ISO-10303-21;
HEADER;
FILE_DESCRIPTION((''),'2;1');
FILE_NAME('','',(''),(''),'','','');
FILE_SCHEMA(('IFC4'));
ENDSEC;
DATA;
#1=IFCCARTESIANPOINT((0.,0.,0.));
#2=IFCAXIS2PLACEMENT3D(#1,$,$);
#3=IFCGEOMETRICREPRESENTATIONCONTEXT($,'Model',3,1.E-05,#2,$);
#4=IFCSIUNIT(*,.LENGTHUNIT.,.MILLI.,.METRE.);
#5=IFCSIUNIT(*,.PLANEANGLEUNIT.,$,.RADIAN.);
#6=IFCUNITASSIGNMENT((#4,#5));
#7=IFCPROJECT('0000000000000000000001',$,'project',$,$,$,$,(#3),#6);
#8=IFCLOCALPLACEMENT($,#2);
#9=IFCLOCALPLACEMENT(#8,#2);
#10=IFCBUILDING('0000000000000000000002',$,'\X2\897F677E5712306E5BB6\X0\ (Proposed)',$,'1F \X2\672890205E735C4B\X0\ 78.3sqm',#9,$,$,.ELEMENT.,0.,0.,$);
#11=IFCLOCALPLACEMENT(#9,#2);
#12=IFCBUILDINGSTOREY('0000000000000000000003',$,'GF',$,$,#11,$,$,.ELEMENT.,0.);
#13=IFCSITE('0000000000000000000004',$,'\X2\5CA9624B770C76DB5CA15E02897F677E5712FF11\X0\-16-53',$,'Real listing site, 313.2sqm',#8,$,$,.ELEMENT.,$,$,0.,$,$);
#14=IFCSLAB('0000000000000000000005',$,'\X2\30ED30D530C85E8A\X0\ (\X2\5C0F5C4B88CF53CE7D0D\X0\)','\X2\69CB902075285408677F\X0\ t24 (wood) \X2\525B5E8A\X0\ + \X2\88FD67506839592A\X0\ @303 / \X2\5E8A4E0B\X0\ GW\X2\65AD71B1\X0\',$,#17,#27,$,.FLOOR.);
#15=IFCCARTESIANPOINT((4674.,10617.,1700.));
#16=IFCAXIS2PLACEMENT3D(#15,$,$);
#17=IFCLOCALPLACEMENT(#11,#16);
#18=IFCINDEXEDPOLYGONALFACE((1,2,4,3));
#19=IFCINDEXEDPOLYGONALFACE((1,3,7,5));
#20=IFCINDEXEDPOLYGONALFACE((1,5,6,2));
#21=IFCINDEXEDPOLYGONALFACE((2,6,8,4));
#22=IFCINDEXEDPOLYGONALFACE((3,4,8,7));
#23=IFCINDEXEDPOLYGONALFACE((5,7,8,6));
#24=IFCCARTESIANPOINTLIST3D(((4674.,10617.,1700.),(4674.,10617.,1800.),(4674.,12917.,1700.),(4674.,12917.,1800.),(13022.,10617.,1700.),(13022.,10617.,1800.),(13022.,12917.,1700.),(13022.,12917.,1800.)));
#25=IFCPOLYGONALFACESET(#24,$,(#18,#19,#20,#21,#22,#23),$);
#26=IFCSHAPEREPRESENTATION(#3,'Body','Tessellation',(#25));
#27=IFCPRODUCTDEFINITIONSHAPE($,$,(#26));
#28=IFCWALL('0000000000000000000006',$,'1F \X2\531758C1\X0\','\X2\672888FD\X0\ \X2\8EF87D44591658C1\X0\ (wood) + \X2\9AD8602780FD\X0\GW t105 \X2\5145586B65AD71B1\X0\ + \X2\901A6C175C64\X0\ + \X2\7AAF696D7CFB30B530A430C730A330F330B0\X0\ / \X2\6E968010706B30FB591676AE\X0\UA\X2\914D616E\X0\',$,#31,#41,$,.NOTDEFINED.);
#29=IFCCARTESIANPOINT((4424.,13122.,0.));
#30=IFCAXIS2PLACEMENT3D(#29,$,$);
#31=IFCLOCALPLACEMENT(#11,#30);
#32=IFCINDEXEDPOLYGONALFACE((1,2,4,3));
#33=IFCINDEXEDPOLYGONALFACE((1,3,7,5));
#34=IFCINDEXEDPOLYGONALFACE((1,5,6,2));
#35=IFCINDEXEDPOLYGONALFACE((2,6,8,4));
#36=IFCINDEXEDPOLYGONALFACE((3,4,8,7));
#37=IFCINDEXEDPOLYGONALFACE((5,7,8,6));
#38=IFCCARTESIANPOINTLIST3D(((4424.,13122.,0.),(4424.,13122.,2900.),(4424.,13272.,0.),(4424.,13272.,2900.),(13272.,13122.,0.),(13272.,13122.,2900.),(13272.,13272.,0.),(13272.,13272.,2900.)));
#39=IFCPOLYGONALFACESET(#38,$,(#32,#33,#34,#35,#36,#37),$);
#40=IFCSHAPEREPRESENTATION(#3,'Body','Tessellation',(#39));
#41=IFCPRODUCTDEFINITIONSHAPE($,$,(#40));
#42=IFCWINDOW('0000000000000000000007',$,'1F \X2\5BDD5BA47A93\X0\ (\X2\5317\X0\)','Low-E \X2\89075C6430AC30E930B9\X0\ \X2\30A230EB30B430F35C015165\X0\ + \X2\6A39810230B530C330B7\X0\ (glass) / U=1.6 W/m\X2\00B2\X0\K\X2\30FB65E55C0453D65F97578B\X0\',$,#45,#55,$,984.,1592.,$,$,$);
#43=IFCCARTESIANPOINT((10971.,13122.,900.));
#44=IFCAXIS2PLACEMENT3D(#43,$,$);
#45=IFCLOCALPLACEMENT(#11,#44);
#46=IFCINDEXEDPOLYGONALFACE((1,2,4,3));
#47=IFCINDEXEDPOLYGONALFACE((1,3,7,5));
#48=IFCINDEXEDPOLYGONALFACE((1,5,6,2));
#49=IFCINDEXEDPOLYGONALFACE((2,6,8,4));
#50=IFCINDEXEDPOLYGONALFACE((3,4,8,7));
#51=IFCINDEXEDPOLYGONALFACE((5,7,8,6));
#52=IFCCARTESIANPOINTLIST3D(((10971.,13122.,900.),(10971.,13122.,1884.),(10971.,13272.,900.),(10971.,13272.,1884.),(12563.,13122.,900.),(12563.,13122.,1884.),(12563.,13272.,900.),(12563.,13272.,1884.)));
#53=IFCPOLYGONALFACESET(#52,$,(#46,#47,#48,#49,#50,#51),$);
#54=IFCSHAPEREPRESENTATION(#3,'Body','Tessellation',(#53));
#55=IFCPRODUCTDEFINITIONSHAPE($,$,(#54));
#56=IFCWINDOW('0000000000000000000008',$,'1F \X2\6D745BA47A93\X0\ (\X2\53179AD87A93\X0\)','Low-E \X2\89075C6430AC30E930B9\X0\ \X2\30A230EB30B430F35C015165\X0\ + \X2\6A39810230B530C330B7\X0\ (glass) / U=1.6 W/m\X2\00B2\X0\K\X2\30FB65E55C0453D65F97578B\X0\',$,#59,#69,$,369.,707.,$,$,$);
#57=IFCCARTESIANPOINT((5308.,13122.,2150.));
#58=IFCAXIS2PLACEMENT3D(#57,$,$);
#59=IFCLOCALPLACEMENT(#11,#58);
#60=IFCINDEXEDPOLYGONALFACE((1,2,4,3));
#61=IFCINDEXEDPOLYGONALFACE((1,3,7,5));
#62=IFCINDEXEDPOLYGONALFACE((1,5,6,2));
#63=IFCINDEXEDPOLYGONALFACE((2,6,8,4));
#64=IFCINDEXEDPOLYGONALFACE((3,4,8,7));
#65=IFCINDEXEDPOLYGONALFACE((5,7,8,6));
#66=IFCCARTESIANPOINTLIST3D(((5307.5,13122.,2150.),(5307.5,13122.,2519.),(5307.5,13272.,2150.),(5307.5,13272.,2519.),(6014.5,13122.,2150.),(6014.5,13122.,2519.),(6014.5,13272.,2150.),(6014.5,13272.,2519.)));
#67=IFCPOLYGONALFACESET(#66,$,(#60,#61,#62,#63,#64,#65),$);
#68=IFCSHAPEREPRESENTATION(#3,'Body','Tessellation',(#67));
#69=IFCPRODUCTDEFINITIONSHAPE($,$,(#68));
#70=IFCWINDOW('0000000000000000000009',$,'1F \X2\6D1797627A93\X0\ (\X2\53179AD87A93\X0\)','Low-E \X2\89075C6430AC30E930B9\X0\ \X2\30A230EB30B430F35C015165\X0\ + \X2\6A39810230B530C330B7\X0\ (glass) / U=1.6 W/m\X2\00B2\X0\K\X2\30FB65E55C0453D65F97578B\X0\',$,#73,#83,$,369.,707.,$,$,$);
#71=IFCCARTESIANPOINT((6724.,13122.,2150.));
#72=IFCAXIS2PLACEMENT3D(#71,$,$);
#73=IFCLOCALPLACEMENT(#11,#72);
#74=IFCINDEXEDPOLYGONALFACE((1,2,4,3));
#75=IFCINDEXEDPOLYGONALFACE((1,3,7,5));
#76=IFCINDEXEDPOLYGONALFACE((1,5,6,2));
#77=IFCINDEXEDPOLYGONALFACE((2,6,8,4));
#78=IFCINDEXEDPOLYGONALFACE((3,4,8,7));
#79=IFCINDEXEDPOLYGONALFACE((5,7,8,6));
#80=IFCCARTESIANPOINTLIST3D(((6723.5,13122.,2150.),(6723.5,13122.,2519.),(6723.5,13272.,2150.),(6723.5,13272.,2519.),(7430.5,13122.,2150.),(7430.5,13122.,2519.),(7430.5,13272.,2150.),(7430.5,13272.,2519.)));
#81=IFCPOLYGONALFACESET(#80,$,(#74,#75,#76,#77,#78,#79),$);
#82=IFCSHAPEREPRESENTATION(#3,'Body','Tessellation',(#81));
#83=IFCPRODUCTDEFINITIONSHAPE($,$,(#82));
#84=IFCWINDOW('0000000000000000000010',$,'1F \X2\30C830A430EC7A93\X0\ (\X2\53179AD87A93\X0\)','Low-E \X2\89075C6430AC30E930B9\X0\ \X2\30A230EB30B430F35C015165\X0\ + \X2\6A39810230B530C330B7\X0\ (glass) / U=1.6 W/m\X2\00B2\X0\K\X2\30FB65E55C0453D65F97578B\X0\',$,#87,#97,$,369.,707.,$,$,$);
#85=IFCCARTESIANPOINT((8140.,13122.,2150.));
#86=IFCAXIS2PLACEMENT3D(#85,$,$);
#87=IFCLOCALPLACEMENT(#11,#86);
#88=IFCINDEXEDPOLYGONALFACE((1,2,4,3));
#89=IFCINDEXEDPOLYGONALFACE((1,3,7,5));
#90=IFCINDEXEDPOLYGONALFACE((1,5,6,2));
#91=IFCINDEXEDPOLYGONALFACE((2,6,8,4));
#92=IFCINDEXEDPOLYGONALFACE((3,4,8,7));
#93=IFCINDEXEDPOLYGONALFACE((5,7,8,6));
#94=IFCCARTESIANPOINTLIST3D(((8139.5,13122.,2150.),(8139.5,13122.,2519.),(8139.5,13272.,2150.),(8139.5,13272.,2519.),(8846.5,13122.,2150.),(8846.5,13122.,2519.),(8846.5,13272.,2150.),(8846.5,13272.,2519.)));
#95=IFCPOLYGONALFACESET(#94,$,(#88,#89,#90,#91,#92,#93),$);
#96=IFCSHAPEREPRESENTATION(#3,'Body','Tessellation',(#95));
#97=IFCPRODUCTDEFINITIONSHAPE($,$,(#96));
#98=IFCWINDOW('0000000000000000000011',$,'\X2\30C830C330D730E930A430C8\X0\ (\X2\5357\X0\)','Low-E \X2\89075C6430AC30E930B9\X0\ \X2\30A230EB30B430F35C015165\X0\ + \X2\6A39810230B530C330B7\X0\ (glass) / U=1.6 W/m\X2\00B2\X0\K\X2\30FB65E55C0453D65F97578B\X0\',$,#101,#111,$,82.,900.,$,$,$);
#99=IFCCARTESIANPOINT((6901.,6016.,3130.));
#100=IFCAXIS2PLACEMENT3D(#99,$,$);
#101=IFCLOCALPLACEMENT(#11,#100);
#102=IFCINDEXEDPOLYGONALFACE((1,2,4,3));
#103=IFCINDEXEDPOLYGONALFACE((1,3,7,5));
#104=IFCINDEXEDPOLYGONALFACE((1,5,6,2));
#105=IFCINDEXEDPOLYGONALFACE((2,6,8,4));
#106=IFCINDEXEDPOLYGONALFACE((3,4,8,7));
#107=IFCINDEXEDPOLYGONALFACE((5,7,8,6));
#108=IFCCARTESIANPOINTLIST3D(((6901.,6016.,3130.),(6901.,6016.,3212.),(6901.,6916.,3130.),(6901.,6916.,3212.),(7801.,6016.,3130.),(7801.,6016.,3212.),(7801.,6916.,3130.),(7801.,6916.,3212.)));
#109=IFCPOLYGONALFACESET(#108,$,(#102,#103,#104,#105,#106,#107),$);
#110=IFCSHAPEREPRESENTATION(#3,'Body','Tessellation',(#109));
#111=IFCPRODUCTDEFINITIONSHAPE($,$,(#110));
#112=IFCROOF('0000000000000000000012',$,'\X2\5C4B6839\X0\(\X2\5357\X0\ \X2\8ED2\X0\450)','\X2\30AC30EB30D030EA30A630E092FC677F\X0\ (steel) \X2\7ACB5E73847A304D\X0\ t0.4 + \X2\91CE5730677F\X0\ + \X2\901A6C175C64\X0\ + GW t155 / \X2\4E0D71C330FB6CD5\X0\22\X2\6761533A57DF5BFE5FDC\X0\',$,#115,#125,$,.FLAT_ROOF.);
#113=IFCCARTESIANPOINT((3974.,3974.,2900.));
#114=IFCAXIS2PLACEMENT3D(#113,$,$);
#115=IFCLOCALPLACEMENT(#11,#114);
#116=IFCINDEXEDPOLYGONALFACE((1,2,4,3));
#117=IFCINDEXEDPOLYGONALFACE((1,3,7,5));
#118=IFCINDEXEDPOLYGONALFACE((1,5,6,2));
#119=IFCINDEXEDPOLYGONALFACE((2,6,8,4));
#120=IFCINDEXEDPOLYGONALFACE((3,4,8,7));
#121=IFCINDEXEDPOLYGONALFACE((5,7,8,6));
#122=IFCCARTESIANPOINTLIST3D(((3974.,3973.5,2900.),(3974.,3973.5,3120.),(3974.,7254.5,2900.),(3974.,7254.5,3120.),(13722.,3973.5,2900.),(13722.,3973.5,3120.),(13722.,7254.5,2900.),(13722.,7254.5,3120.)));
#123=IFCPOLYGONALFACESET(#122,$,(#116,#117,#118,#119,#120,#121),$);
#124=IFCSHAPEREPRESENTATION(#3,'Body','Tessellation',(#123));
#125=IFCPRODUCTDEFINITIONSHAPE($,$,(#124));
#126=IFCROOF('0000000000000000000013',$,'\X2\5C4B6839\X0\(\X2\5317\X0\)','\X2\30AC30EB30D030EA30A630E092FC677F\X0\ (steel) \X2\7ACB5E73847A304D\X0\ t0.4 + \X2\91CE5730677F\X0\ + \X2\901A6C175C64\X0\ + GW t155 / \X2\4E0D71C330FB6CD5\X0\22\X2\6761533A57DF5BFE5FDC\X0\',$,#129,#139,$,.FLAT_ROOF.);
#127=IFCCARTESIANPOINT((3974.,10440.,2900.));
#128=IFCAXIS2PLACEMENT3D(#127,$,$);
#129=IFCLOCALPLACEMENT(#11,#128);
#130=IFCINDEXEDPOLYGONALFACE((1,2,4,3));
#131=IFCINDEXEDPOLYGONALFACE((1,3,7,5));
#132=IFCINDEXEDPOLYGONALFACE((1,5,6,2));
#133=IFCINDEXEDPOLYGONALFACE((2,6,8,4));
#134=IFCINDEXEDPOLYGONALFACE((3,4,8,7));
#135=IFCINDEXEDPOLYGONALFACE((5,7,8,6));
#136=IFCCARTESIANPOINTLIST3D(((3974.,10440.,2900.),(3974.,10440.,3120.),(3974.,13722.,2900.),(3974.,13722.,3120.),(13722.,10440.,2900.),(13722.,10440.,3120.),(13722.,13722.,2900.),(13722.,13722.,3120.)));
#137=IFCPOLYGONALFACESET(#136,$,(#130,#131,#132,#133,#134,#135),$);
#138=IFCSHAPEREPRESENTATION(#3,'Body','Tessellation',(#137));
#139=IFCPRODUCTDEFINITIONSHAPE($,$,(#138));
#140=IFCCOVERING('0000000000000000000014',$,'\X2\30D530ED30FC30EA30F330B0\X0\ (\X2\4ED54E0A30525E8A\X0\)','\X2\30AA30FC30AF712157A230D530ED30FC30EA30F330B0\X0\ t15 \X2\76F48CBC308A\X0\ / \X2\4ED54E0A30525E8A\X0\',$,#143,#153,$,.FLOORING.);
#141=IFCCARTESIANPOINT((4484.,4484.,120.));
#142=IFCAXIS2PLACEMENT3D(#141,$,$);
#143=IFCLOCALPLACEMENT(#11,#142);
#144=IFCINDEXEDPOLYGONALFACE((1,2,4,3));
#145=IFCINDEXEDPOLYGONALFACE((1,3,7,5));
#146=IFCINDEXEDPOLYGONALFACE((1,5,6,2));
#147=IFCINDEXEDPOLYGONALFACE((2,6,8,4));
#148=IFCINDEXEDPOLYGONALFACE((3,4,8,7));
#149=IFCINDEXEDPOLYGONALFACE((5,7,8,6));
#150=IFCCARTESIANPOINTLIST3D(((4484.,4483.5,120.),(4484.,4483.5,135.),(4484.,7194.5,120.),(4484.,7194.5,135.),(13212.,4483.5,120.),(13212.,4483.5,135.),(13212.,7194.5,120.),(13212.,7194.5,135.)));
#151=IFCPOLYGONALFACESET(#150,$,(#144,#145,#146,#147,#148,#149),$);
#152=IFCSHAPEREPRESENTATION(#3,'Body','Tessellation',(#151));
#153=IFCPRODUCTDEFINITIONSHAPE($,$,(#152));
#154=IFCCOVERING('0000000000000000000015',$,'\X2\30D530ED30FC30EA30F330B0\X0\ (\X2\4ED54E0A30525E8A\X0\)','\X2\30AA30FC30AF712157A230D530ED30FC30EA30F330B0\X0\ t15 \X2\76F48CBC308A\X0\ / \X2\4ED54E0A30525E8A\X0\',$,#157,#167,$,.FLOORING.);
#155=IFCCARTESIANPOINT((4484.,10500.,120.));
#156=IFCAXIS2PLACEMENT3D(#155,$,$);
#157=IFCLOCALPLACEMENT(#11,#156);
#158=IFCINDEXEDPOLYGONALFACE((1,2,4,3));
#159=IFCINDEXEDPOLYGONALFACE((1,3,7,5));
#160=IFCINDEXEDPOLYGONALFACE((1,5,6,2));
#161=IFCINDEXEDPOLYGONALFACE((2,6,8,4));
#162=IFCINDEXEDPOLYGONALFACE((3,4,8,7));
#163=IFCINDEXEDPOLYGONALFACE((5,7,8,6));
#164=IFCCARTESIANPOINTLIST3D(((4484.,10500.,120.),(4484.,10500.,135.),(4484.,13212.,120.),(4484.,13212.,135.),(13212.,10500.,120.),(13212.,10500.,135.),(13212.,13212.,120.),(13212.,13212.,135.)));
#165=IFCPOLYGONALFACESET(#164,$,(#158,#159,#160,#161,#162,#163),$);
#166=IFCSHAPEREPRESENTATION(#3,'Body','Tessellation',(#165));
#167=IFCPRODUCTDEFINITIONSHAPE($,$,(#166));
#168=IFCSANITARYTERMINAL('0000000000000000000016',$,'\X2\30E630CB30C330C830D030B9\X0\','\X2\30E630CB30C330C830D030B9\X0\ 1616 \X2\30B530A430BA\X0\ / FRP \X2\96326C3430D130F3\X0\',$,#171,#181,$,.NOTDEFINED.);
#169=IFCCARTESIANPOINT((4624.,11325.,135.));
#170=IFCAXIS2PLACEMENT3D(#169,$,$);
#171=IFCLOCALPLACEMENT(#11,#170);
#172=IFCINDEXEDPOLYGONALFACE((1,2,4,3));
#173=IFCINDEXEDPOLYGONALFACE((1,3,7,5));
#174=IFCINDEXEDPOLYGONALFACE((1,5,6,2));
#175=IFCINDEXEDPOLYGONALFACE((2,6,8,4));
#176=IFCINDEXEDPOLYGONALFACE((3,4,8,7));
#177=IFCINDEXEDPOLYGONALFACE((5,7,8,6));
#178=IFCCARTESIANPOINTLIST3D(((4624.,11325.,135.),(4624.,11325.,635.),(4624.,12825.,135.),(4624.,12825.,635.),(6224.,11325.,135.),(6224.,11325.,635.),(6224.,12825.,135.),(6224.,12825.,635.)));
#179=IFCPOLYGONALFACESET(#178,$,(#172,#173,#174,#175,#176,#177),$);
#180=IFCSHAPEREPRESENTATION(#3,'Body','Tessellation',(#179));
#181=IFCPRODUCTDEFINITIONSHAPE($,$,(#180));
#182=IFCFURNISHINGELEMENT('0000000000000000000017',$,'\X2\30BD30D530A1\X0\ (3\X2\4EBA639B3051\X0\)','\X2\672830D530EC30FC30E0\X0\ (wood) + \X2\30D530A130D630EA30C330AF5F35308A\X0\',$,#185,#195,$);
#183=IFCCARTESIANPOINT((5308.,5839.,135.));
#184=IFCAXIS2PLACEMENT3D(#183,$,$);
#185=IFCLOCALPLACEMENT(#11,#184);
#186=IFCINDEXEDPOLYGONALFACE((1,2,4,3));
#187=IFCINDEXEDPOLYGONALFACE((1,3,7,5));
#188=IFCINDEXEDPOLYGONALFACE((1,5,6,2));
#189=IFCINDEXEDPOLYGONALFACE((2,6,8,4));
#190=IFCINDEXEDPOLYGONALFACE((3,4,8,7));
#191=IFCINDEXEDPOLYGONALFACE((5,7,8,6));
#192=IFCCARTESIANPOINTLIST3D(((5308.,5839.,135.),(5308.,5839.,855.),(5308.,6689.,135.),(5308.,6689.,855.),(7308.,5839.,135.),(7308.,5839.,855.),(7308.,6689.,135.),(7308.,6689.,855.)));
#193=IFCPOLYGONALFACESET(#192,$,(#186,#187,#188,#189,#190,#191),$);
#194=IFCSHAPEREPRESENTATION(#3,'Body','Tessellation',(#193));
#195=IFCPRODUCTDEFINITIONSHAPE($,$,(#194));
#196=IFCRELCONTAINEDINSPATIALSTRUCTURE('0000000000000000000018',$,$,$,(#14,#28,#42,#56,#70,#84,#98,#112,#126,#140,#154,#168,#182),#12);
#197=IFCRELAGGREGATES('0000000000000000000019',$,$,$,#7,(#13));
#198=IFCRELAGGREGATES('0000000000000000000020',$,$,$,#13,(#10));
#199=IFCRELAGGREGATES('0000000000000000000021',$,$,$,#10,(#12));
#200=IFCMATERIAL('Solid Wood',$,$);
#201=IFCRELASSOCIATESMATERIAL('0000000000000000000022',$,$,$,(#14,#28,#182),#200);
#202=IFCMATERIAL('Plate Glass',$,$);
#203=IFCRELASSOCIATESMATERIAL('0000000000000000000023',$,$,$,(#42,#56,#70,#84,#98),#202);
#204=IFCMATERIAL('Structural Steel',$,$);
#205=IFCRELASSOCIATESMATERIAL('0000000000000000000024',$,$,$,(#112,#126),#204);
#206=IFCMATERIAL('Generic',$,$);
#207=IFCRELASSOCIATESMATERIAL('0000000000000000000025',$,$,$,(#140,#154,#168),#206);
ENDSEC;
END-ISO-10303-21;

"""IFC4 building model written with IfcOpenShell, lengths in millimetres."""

from ifc_helpers import new_model, si_unit, frame, frame_2d, origin, place, context, project, spatial, rectangle, extrude, material, element, fill, save


model = new_model("IFC4")

# Units and contexts
model_context = context("Model", 3, precision=1e-05, world=origin())
ifc_project = project(units=[si_unit("LENGTHUNIT", "METRE", prefix="MILLI"), si_unit("PLANEANGLEUNIT", "RADIAN")], contexts=[model_context])

# Site, building, storey
site_placement = place(None, origin())
site = spatial("IfcSite", under=ifc_project, at=site_placement, Name="岩手県盛岡市西松園１-16-53", ObjectType="Real listing site, 313.2sqm", CompositionType="ELEMENT", RefElevation=0.0)
building_placement = place(site_placement, origin())
building = spatial("IfcBuilding", under=site, at=building_placement, Name="西松園の家 (Proposed)", ObjectType="1F 木造平屋 78.3sqm", CompositionType="ELEMENT", ElevationOfRefHeight=0.0, ElevationOfTerrain=0.0)
storey_placement = place(building_placement, origin())
storey = spatial("IfcBuildingStorey", under=building, at=storey_placement, Name="GF", CompositionType="ELEMENT", Elevation=0.0)

# Slab
ifc_material_1 = material(Name="Solid Wood")
slab_1_placement = place(storey_placement, frame((4674.0, 10617.0, 1700.0)))
element("IfcSlab", 1, at=slab_1_placement, inside=storey, material=ifc_material_1, Name="ロフト床 (小屋裏収納)", Description="構造用合板 t24 (wood) 剛床 + 製材根太 @303 / 床下 GW断熱", PredefinedType="FLOOR", context=model_context, shape_type="SweptSolid", body=[
    extrude(rectangle(XDim=8348.0, YDim=2300.0, at=frame_2d((4174.0, 1150.0))), frame((4674.0, 10617.0, 1700.0)), (0.0, 0.0, 1.0), 100.0),
])

# Shared definitions
ifc_material_2 = material(Name="Plate Glass")

# Wall, openings, windows
wall_1_placement = place(storey_placement, frame((4424.0, 13122.0, 0.0)))
wall_1 = element("IfcWall", 2, at=wall_1_placement, inside=storey, material=ifc_material_1, Name="1F 北壁", Description="木製 軸組外壁 (wood) + 高性能GW t105 充填断熱 + 通気層 + 窯業系サイディング / 準耐火・外皮UA配慮", PredefinedType="NOTDEFINED", context=model_context, shape_type="SweptSolid", body=[
    extrude(rectangle(XDim=8848.0, YDim=150.0, at=frame_2d((4424.0, 75.0))), frame((4424.0, 13122.0, 0.0)), (0.0, 0.0, 1.0), 2900.0),
])
opening_1_placement = place(storey_placement, frame((10971.0, 13122.0, 900.0)))
opening_1 = element("IfcOpeningElement", 3, at=opening_1_placement, cuts=wall_1, PredefinedType="NOTDEFINED", context=model_context, shape_type="SweptSolid", body=[
    extrude(rectangle(XDim=1592.0, YDim=150.0, at=frame_2d((796.0, 75.0))), frame((10971.0, 13122.0, 900.0)), (0.0, 0.0, 1.0), 984.0),
])
opening_2_placement = place(storey_placement, frame((5308.0, 13122.0, 2150.0)))
opening_2 = element("IfcOpeningElement", 4, at=opening_2_placement, cuts=wall_1, PredefinedType="NOTDEFINED", context=model_context, shape_type="SweptSolid", body=[
    extrude(rectangle(XDim=707.0, YDim=150.0, at=frame_2d((353.0, 75.0))), frame((5308.0, 13122.0, 2150.0)), (0.0, 0.0, 1.0), 369.0),
])
opening_3_placement = place(storey_placement, frame((6724.0, 13122.0, 2150.0)))
opening_3 = element("IfcOpeningElement", 5, at=opening_3_placement, cuts=wall_1, PredefinedType="NOTDEFINED", context=model_context, shape_type="SweptSolid", body=[
    extrude(rectangle(XDim=707.0, YDim=150.0, at=frame_2d((353.0, 75.0))), frame((6724.0, 13122.0, 2150.0)), (0.0, 0.0, 1.0), 369.0),
])
opening_4_placement = place(storey_placement, frame((8140.0, 13122.0, 2150.0)))
opening_4 = element("IfcOpeningElement", 6, at=opening_4_placement, cuts=wall_1, PredefinedType="NOTDEFINED", context=model_context, shape_type="SweptSolid", body=[
    extrude(rectangle(XDim=707.0, YDim=150.0, at=frame_2d((353.0, 75.0))), frame((8140.0, 13122.0, 2150.0)), (0.0, 0.0, 1.0), 369.0),
])
window_1_placement = place(storey_placement, frame((10971.0, 13122.0, 900.0)))
window_1 = element("IfcWindow", 7, at=window_1_placement, inside=storey, material=ifc_material_2, Name="1F 寝室窓 (北)", Description="Low-E 複層ガラス アルゴン封入 + 樹脂サッシ (glass) / U=1.6 W/m²K・日射取得型", OverallHeight=984.0, OverallWidth=1592.0, context=model_context, shape_type="SweptSolid", body=[
    extrude(rectangle(XDim=1592.0, YDim=150.0, at=frame_2d((796.0, 75.0))), frame((10971.0, 13122.0, 900.0)), (0.0, 0.0, 1.0), 984.0),
])
fill(opening_1, window_1)
window_2_placement = place(storey_placement, frame((5308.0, 13122.0, 2150.0)))
window_2 = element("IfcWindow", 8, at=window_2_placement, inside=storey, material=ifc_material_2, Name="1F 浴室窓 (北高窓)", Description="Low-E 複層ガラス アルゴン封入 + 樹脂サッシ (glass) / U=1.6 W/m²K・日射取得型", OverallHeight=369.0, OverallWidth=707.0, context=model_context, shape_type="SweptSolid", body=[
    extrude(rectangle(XDim=707.0, YDim=150.0, at=frame_2d((353.0, 75.0))), frame((5308.0, 13122.0, 2150.0)), (0.0, 0.0, 1.0), 369.0),
])
fill(opening_2, window_2)
window_3_placement = place(storey_placement, frame((6724.0, 13122.0, 2150.0)))
window_3 = element("IfcWindow", 9, at=window_3_placement, inside=storey, material=ifc_material_2, Name="1F 洗面窓 (北高窓)", Description="Low-E 複層ガラス アルゴン封入 + 樹脂サッシ (glass) / U=1.6 W/m²K・日射取得型", OverallHeight=369.0, OverallWidth=707.0, context=model_context, shape_type="SweptSolid", body=[
    extrude(rectangle(XDim=707.0, YDim=150.0, at=frame_2d((353.0, 75.0))), frame((6724.0, 13122.0, 2150.0)), (0.0, 0.0, 1.0), 369.0),
])
fill(opening_3, window_3)
window_4_placement = place(storey_placement, frame((8140.0, 13122.0, 2150.0)))
window_4 = element("IfcWindow", 10, at=window_4_placement, inside=storey, material=ifc_material_2, Name="1F トイレ窓 (北高窓)", Description="Low-E 複層ガラス アルゴン封入 + 樹脂サッシ (glass) / U=1.6 W/m²K・日射取得型", OverallHeight=369.0, OverallWidth=707.0, context=model_context, shape_type="SweptSolid", body=[
    extrude(rectangle(XDim=707.0, YDim=150.0, at=frame_2d((353.0, 75.0))), frame((8140.0, 13122.0, 2150.0)), (0.0, 0.0, 1.0), 369.0),
])
fill(opening_4, window_4)

# Window
window_5_placement = place(storey_placement, frame((6901.0, 6016.0, 3130.0)))
element("IfcWindow", 11, at=window_5_placement, inside=storey, material=ifc_material_2, Name="トップライト (南)", Description="Low-E 複層ガラス アルゴン封入 + 樹脂サッシ (glass) / U=1.6 W/m²K・日射取得型", OverallHeight=82.0, OverallWidth=900.0, context=model_context, shape_type="SweptSolid", body=[
    extrude(rectangle(XDim=900.0, YDim=900.0, at=frame_2d((450.0, 450.0))), frame((6901.0, 6016.0, 3130.0)), (0.0, 0.0, 1.0), 82.0),
])

# Roofs
ifc_material_3 = material(Name="Structural Steel")
roof_1_placement = place(storey_placement, frame((3974.0, 3974.0, 2900.0)))
element("IfcRoof", 12, at=roof_1_placement, inside=storey, material=ifc_material_3, Name="屋根(南 軒450)", Description="ガルバリウム鋼板 (steel) 立平葺き t0.4 + 野地板 + 通気層 + GW t155 / 不燃・法22条区域対応", PredefinedType="FLAT_ROOF", context=model_context, shape_type="SweptSolid", body=[
    extrude(rectangle(XDim=9748.0, YDim=3281.0, at=frame_2d((4874.0, 1640.0))), frame((3974.0, 3974.0, 2900.0)), (0.0, 0.0, 1.0), 220.0),
])
roof_2_placement = place(storey_placement, frame((3974.0, 10440.0, 2900.0)))
element("IfcRoof", 13, at=roof_2_placement, inside=storey, material=ifc_material_3, Name="屋根(北)", Description="ガルバリウム鋼板 (steel) 立平葺き t0.4 + 野地板 + 通気層 + GW t155 / 不燃・法22条区域対応", PredefinedType="FLAT_ROOF", context=model_context, shape_type="SweptSolid", body=[
    extrude(rectangle(XDim=9748.0, YDim=3282.0, at=frame_2d((4874.0, 1641.0))), frame((3974.0, 10440.0, 2900.0)), (0.0, 0.0, 1.0), 220.0),
])

# Coverings
ifc_material_4 = material(Name="Generic")
covering_1_placement = place(storey_placement, frame((4484.0, 4484.0, 120.0)))
element("IfcCovering", 14, at=covering_1_placement, inside=storey, material=ifc_material_4, Name="フローリング (仕上げ床)", Description="オーク無垢フローリング t15 直貼り / 仕上げ床", PredefinedType="FLOORING", context=model_context, shape_type="SweptSolid", body=[
    extrude(rectangle(XDim=8728.0, YDim=2711.0, at=frame_2d((4364.0, 1355.0))), frame((4484.0, 4484.0, 120.0)), (0.0, 0.0, 1.0), 15.0),
])
covering_2_placement = place(storey_placement, frame((4484.0, 10500.0, 120.0)))
element("IfcCovering", 15, at=covering_2_placement, inside=storey, material=ifc_material_4, Name="フローリング (仕上げ床)", Description="オーク無垢フローリング t15 直貼り / 仕上げ床", PredefinedType="FLOORING", context=model_context, shape_type="SweptSolid", body=[
    extrude(rectangle(XDim=8728.0, YDim=2712.0, at=frame_2d((4364.0, 1356.0))), frame((4484.0, 10500.0, 120.0)), (0.0, 0.0, 1.0), 15.0),
])

# Sanitary terminal
sanitary_terminal_placement = place(storey_placement, frame((4624.0, 11325.0, 135.0)))
element("IfcSanitaryTerminal", 16, at=sanitary_terminal_placement, inside=storey, material=ifc_material_4, Name="ユニットバス", Description="ユニットバス 1616 サイズ / FRP 防水パン", PredefinedType="NOTDEFINED", context=model_context, shape_type="SweptSolid", body=[
    extrude(rectangle(XDim=1600.0, YDim=1500.0, at=frame_2d((800.0, 750.0))), frame((4624.0, 11325.0, 135.0)), (0.0, 0.0, 1.0), 500.0),
])

# Furnishing element
furnishing_1_placement = place(storey_placement, frame((5308.0, 5839.0, 135.0)))
element("IfcFurnishingElement", 17, at=furnishing_1_placement, inside=storey, material=ifc_material_1, Name="ソファ (3人掛け)", Description="木フレーム (wood) + ファブリック張り", context=model_context, shape_type="SweptSolid", body=[
    extrude(rectangle(XDim=2000.0, YDim=850.0, at=frame_2d((1000.0, 425.0))), frame((5308.0, 5839.0, 135.0)), (0.0, 0.0, 1.0), 720.0),
])

save(model, "model.ifc")
